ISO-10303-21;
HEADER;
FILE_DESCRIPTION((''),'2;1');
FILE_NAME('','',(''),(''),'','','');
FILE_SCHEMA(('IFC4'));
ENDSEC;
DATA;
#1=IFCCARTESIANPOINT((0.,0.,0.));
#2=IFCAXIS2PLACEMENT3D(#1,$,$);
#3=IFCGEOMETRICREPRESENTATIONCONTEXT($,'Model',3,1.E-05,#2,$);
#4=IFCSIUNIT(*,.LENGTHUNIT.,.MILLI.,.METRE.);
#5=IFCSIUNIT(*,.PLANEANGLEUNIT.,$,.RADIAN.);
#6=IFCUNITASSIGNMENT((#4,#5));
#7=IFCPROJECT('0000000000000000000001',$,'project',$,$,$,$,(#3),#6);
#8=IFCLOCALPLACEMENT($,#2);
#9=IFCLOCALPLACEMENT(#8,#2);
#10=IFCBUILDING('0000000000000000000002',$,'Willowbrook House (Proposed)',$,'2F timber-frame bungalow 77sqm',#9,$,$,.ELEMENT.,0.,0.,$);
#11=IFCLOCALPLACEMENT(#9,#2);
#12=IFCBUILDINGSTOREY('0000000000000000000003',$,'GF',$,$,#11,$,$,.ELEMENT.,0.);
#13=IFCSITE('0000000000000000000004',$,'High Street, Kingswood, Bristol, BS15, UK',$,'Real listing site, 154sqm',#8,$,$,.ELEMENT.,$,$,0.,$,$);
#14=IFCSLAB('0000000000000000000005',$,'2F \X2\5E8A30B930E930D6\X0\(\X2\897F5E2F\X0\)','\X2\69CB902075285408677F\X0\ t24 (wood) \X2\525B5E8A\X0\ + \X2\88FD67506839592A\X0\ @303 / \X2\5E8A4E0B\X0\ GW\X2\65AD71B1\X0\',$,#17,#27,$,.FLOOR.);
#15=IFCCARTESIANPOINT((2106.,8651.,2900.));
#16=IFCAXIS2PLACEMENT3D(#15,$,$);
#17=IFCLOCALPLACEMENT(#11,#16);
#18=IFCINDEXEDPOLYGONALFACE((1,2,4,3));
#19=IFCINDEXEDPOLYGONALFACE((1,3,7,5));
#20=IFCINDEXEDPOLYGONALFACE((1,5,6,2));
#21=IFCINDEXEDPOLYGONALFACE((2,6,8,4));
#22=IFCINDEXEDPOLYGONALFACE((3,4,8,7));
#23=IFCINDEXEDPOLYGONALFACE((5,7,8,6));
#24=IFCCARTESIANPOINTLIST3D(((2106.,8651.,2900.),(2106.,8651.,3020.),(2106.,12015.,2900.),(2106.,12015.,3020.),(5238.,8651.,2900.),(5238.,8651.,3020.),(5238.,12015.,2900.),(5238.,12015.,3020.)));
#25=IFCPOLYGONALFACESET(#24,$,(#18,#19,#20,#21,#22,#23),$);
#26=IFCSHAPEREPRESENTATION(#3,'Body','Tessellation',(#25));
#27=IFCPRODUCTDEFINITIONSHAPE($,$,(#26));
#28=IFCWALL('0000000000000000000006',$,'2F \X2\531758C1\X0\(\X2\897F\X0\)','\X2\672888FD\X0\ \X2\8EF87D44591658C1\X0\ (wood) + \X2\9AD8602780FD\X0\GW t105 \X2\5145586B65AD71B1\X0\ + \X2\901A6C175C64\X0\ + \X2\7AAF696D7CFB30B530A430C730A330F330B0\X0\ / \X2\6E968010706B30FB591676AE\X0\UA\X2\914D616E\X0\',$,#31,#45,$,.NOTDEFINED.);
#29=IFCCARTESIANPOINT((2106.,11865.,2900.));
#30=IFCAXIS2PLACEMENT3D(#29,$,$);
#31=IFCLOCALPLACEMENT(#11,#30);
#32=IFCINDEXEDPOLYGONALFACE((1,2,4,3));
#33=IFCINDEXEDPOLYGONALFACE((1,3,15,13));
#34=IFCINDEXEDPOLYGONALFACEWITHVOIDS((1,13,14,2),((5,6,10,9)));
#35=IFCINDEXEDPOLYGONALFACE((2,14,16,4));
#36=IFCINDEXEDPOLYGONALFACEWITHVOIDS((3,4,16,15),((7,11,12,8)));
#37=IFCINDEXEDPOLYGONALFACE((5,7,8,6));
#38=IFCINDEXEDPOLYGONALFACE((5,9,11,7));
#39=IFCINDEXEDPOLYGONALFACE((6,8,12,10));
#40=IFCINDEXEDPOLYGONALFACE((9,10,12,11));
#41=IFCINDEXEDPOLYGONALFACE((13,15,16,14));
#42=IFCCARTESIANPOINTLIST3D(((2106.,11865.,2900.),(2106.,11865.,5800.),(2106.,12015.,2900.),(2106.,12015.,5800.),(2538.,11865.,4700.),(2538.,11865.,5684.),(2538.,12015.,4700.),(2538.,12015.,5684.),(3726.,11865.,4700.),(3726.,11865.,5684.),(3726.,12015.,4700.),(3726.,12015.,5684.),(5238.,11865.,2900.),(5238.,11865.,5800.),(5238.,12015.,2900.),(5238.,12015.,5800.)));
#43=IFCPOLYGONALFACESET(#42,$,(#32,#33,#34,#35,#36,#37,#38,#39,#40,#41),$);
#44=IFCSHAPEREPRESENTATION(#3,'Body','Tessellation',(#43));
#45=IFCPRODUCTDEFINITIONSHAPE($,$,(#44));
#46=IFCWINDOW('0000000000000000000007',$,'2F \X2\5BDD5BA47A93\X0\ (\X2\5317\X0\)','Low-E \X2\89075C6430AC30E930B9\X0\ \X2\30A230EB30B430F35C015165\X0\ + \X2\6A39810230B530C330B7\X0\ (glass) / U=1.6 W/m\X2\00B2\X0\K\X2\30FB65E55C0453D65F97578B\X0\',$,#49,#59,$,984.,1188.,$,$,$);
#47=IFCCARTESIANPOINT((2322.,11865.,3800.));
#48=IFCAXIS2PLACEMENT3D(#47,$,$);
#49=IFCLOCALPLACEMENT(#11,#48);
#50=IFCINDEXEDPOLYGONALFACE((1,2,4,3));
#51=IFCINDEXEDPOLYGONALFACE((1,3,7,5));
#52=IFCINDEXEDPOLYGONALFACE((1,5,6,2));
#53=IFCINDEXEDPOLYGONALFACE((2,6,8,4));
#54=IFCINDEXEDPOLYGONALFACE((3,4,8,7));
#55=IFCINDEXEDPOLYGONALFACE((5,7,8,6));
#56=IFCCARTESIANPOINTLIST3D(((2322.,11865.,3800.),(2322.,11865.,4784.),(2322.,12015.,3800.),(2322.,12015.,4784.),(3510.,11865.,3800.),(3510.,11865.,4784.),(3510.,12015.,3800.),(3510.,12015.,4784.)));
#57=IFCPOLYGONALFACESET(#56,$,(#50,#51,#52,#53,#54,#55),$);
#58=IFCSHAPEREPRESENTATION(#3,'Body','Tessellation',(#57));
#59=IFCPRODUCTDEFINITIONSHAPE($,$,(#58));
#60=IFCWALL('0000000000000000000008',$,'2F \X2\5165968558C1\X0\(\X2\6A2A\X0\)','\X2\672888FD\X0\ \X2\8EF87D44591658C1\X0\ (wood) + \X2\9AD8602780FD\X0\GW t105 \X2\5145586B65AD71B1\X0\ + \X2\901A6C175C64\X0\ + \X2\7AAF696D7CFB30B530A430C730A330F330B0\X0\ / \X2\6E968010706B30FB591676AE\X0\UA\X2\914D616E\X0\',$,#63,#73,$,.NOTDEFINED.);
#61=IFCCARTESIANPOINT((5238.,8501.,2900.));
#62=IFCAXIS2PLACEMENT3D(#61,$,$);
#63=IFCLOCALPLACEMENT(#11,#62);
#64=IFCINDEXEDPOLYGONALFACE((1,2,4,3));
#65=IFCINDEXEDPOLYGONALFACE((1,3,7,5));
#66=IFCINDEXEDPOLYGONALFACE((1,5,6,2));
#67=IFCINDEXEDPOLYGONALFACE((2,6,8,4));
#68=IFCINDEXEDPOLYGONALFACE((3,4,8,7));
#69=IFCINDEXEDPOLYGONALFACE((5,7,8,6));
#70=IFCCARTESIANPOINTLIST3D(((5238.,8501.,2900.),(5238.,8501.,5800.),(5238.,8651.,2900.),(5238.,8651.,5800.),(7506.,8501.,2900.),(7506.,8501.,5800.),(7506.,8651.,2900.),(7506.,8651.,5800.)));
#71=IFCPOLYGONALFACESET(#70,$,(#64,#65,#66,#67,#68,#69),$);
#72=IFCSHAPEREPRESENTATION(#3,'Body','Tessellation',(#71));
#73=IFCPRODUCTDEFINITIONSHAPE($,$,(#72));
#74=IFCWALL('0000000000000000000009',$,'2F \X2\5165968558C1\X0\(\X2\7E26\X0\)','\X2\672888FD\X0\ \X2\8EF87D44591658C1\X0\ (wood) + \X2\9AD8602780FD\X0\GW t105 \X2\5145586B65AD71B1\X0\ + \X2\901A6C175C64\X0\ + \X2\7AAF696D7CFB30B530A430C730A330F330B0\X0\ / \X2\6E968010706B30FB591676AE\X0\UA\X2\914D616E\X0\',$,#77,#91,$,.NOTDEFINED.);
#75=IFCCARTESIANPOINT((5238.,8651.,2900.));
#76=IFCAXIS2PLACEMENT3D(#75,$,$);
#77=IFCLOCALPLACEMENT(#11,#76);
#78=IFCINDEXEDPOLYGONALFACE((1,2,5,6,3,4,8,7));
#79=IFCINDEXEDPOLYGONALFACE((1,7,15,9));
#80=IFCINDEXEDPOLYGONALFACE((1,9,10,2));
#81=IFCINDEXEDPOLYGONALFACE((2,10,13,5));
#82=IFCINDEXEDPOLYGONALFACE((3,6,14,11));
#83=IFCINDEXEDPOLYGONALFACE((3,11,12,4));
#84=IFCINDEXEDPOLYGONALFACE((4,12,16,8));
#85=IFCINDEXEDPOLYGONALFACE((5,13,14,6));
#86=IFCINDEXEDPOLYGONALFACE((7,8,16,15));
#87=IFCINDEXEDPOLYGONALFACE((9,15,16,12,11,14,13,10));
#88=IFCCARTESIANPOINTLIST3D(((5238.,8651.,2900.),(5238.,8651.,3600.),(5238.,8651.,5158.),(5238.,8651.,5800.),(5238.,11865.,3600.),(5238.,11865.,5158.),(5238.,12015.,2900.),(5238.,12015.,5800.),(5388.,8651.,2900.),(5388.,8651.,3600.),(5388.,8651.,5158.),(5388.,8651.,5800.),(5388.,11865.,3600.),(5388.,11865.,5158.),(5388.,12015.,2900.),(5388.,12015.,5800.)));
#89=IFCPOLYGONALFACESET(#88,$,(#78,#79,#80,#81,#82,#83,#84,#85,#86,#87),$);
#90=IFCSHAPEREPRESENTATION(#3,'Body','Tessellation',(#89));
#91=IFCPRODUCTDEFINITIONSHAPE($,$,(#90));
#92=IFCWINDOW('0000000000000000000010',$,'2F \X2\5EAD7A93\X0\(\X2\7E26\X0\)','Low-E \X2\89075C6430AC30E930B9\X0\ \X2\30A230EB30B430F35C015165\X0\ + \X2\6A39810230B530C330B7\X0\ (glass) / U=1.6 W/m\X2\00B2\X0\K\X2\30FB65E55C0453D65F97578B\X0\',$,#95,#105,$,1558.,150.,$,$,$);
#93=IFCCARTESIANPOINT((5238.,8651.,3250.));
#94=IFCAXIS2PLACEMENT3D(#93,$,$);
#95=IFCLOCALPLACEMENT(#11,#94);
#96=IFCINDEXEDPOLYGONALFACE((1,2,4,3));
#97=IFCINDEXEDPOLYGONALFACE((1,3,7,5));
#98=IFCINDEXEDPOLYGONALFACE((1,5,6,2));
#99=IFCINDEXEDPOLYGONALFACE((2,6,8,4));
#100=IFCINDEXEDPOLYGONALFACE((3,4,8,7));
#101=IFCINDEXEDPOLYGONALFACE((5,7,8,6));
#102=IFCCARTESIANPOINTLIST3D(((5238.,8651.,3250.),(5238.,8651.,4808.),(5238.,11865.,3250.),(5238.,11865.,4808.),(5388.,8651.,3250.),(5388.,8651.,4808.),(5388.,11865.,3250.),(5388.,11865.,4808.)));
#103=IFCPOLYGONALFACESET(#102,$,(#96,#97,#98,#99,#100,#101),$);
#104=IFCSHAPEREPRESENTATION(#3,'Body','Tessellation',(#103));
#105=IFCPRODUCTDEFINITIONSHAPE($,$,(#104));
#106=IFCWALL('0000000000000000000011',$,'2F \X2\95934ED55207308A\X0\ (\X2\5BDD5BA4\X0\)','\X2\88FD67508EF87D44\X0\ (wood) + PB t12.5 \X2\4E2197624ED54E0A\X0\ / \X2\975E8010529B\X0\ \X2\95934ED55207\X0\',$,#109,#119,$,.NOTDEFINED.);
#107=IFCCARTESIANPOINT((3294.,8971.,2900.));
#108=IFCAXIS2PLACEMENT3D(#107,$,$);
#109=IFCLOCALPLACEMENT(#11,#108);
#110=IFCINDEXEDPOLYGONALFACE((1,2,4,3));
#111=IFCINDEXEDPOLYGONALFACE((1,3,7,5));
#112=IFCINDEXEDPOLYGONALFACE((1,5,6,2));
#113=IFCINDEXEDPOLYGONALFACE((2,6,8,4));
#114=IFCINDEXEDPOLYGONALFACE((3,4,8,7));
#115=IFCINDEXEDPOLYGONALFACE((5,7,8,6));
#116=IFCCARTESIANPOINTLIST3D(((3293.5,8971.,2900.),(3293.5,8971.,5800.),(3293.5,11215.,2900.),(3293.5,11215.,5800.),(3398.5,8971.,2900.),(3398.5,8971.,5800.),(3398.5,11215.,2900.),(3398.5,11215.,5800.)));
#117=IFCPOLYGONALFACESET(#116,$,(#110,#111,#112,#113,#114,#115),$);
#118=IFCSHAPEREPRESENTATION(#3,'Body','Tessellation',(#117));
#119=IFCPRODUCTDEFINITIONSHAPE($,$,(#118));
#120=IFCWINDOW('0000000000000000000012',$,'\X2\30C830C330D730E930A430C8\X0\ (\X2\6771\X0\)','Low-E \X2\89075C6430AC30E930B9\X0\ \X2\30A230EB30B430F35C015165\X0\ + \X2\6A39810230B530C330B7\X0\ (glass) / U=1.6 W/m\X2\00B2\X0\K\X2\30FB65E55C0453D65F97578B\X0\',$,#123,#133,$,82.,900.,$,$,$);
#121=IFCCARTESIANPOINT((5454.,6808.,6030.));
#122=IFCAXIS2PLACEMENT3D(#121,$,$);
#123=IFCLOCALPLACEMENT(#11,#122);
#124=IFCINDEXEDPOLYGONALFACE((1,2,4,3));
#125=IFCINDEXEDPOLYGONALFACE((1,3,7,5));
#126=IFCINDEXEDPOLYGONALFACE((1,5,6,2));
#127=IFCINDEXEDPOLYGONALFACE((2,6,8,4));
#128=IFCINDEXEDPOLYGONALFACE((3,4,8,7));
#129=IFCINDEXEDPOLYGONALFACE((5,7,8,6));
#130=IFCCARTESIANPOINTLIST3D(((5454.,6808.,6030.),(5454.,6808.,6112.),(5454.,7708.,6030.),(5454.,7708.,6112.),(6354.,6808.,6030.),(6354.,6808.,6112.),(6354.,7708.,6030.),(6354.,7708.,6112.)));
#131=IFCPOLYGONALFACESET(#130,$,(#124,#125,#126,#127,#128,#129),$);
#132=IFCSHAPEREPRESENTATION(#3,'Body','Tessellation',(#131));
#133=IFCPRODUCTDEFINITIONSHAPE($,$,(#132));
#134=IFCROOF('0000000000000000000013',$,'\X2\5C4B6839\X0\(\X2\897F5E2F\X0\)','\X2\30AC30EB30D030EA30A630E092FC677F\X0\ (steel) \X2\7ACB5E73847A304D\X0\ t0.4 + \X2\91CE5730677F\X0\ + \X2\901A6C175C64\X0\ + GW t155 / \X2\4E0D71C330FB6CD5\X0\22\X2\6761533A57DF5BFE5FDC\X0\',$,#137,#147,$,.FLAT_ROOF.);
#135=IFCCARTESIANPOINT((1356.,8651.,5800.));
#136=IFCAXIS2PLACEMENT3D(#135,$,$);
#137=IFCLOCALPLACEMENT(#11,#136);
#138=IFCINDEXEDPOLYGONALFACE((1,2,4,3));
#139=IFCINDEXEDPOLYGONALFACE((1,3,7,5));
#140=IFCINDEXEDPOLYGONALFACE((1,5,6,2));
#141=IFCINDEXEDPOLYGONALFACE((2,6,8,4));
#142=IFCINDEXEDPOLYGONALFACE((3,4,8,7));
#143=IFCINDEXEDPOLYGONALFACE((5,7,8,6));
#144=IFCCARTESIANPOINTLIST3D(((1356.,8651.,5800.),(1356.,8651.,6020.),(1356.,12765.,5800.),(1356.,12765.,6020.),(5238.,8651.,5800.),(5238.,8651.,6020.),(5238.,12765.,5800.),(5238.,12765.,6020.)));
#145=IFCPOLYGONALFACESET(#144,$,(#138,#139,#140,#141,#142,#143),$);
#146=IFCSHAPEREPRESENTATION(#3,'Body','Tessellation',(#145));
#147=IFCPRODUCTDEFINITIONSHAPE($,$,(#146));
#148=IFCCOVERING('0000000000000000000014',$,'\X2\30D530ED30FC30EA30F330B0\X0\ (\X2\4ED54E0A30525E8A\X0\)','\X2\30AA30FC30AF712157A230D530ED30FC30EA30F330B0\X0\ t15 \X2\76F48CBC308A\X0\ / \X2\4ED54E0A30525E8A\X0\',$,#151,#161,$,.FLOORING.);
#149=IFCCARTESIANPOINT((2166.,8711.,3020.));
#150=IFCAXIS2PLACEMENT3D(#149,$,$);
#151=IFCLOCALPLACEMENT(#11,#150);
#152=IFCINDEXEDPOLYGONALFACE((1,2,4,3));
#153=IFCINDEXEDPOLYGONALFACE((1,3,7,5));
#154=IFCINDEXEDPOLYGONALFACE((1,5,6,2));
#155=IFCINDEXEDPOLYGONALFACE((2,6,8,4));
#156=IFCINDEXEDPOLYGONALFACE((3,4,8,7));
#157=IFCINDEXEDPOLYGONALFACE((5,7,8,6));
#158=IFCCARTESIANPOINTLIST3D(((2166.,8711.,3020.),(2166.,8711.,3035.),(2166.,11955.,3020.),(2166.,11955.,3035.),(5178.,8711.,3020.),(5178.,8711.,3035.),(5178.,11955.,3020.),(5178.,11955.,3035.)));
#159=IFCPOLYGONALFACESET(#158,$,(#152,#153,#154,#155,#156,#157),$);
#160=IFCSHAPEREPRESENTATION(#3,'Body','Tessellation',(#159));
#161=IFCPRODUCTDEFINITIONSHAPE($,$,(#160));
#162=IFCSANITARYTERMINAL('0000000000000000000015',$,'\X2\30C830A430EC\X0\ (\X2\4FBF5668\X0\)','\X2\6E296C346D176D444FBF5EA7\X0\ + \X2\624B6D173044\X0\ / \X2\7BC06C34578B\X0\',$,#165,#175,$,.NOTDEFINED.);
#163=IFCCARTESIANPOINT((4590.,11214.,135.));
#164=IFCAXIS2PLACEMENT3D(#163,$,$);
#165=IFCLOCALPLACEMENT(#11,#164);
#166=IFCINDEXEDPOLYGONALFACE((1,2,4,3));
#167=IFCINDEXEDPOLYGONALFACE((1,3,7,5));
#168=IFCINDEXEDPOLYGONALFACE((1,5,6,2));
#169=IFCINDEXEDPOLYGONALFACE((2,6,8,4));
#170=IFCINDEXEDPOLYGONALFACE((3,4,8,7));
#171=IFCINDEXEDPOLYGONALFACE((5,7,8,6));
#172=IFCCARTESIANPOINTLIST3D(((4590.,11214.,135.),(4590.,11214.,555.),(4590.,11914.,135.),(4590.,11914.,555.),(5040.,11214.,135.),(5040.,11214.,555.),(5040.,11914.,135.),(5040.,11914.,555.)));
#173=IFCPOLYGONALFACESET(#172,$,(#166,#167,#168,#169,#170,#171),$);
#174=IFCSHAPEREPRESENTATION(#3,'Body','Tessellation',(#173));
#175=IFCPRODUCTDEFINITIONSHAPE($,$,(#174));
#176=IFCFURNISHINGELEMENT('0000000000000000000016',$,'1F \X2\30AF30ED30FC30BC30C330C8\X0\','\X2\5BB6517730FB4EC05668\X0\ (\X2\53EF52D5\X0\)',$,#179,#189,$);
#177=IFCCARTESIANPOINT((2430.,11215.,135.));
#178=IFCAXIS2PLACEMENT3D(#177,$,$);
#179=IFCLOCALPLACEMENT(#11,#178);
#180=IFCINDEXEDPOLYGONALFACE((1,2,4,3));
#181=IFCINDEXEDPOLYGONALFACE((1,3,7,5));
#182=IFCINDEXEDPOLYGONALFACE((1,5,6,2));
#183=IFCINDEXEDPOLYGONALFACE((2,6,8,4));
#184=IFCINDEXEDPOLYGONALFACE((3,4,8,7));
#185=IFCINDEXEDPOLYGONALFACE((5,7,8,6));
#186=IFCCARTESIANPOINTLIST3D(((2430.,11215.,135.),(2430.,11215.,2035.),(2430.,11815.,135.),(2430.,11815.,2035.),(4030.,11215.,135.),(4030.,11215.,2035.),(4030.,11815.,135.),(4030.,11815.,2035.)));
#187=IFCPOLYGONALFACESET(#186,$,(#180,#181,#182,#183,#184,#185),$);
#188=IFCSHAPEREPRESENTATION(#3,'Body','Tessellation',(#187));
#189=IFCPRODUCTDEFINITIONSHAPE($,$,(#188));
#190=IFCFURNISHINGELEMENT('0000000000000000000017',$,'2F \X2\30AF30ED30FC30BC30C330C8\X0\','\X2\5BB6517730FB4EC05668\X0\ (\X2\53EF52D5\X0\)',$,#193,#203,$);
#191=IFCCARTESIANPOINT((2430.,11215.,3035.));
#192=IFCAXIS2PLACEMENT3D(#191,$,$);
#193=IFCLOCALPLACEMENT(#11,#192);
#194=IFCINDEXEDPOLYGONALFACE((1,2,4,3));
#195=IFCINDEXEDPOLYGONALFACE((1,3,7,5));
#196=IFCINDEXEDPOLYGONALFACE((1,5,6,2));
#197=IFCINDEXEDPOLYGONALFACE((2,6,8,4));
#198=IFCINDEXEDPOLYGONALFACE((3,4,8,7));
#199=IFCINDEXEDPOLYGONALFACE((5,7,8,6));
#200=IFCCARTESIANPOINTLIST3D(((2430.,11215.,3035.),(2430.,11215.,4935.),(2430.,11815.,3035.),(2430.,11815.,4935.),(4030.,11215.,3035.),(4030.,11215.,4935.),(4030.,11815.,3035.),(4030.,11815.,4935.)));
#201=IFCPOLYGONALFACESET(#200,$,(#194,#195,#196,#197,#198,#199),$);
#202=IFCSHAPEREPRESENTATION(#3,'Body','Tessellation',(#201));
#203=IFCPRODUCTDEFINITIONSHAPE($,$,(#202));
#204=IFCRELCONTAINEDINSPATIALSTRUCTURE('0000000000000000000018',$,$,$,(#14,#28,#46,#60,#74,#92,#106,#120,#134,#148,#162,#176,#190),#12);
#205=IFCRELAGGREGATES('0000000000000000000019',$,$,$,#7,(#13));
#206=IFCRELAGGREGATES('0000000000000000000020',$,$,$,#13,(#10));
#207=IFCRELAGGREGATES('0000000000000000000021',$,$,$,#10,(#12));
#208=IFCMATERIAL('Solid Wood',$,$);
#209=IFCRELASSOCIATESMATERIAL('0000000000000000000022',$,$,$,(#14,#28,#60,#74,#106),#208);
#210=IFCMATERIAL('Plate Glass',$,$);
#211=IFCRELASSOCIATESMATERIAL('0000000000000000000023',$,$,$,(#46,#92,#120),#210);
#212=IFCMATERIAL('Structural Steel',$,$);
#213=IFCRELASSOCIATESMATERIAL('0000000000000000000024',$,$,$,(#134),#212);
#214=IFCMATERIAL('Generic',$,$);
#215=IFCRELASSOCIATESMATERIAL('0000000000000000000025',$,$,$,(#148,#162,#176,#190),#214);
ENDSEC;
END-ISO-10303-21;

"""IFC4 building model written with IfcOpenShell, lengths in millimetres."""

from ifc_helpers import new_model, si_unit, frame, frame_2d, origin, place, context, project, spatial, rectangle, extrude, material, element, fill, save


model = new_model("IFC4")

# Units and contexts
model_context = context("Model", 3, precision=1e-05, world=origin())
ifc_project = project(units=[si_unit("LENGTHUNIT", "METRE", prefix="MILLI"), si_unit("PLANEANGLEUNIT", "RADIAN")], contexts=[model_context])

# Site, building, storey
site_placement = place(None, origin())
site = spatial("IfcSite", under=ifc_project, at=site_placement, Name="High Street, Kingswood, Bristol, BS15, UK", ObjectType="Real listing site, 154sqm", CompositionType="ELEMENT", RefElevation=0.0)
building_placement = place(site_placement, origin())
building = spatial("IfcBuilding", under=site, at=building_placement, Name="Willowbrook House (Proposed)", ObjectType="2F timber-frame bungalow 77sqm", CompositionType="ELEMENT", ElevationOfRefHeight=0.0, ElevationOfTerrain=0.0)
storey_placement = place(building_placement, origin())
storey = spatial("IfcBuildingStorey", under=building, at=storey_placement, Name="GF", CompositionType="ELEMENT", Elevation=0.0)

# Slab
ifc_material_1 = material(Name="Solid Wood")
slab_placement = place(storey_placement, frame((2106.0, 8651.0, 2900.0)))
element("IfcSlab", 1, at=slab_placement, inside=storey, material=ifc_material_1, Name="2F 床スラブ(西帯)", Description="構造用合板 t24 (wood) 剛床 + 製材根太 @303 / 床下 GW断熱", PredefinedType="FLOOR", context=model_context, shape_type="SweptSolid", body=[
    extrude(rectangle(XDim=3132.0, YDim=3364.0, at=frame_2d((1566.0, 1682.0))), frame((2106.0, 8651.0, 2900.0)), (0.0, 0.0, 1.0), 120.0),
])

# Wall, opening, window
wall_1_placement = place(storey_placement, frame((2106.0, 11865.0, 2900.0)))
wall_1 = element("IfcWall", 2, at=wall_1_placement, inside=storey, material=ifc_material_1, Name="2F 北壁(西)", Description="木製 軸組外壁 (wood) + 高性能GW t105 充填断熱 + 通気層 + 窯業系サイディング / 準耐火・外皮UA配慮", PredefinedType="NOTDEFINED", context=model_context, shape_type="SweptSolid", body=[
    extrude(rectangle(XDim=3132.0, YDim=150.0, at=frame_2d((1566.0, 75.0))), frame((2106.0, 11865.0, 2900.0)), (0.0, 0.0, 1.0), 2900.0),
])
opening_1_placement = place(storey_placement, frame((2322.0, 11865.0, 3800.0)))
opening_1 = element("IfcOpeningElement", 3, at=opening_1_placement, cuts=wall_1, PredefinedType="NOTDEFINED", context=model_context, shape_type="SweptSolid", body=[
    extrude(rectangle(XDim=1188.0, YDim=150.0, at=frame_2d((594.0, 75.0))), frame((2322.0, 11865.0, 3800.0)), (0.0, 0.0, 1.0), 984.0),
])
ifc_material_2 = material(Name="Plate Glass")
window_1_placement = place(storey_placement, frame((2322.0, 11865.0, 3800.0)))
window_1 = element("IfcWindow", 4, at=window_1_placement, inside=storey, material=ifc_material_2, Name="2F 寝室窓 (北)", Description="Low-E 複層ガラス アルゴン封入 + 樹脂サッシ (glass) / U=1.6 W/m²K・日射取得型", OverallHeight=984.0, OverallWidth=1188.0, context=model_context, shape_type="SweptSolid", body=[
    extrude(rectangle(XDim=1188.0, YDim=150.0, at=frame_2d((594.0, 75.0))), frame((2322.0, 11865.0, 3800.0)), (0.0, 0.0, 1.0), 984.0),
])
fill(opening_1, window_1)

# Wall
wall_2_placement = place(storey_placement, frame((5238.0, 8501.0, 2900.0)))
element("IfcWall", 5, at=wall_2_placement, inside=storey, material=ifc_material_1, Name="2F 入隅壁(横)", Description="木製 軸組外壁 (wood) + 高性能GW t105 充填断熱 + 通気層 + 窯業系サイディング / 準耐火・外皮UA配慮", PredefinedType="NOTDEFINED", context=model_context, shape_type="SweptSolid", body=[
    extrude(rectangle(XDim=2268.0, YDim=150.0, at=frame_2d((1134.0, 75.0))), frame((5238.0, 8501.0, 2900.0)), (0.0, 0.0, 1.0), 2900.0),
])

# Wall, opening, window
wall_3_placement = place(storey_placement, frame((5238.0, 8651.0, 2900.0)))
wall_3 = element("IfcWall", 6, at=wall_3_placement, inside=storey, material=ifc_material_1, Name="2F 入隅壁(縦)", Description="木製 軸組外壁 (wood) + 高性能GW t105 充填断熱 + 通気層 + 窯業系サイディング / 準耐火・外皮UA配慮", PredefinedType="NOTDEFINED", context=model_context, shape_type="SweptSolid", body=[
    extrude(rectangle(XDim=150.0, YDim=3364.0, at=frame_2d((75.0, 1682.0))), frame((5238.0, 8651.0, 2900.0)), (0.0, 0.0, 1.0), 2900.0),
])
opening_2_placement = place(storey_placement, frame((5238.0, 8651.0, 3250.0)))
opening_2 = element("IfcOpeningElement", 7, at=opening_2_placement, cuts=wall_3, PredefinedType="NOTDEFINED", context=model_context, shape_type="SweptSolid", body=[
    extrude(rectangle(XDim=150.0, YDim=3214.0, at=frame_2d((75.0, 1607.0))), frame((5238.0, 8651.0, 3250.0)), (0.0, 0.0, 1.0), 1558.0),
])
window_2_placement = place(storey_placement, frame((5238.0, 8651.0, 3250.0)))
window_2 = element("IfcWindow", 8, at=window_2_placement, inside=storey, material=ifc_material_2, Name="2F 庭窓(縦)", Description="Low-E 複層ガラス アルゴン封入 + 樹脂サッシ (glass) / U=1.6 W/m²K・日射取得型", OverallHeight=1558.0, OverallWidth=150.0, context=model_context, shape_type="SweptSolid", body=[
    extrude(rectangle(XDim=150.0, YDim=3214.0, at=frame_2d((75.0, 1607.0))), frame((5238.0, 8651.0, 3250.0)), (0.0, 0.0, 1.0), 1558.0),
])
fill(opening_2, window_2)

# Wall
wall_4_placement = place(storey_placement, frame((3294.0, 8971.0, 2900.0)))
element("IfcWall", 9, at=wall_4_placement, inside=storey, material=ifc_material_1, Name="2F 間仕切り (寝室)", Description="製材軸組 (wood) + PB t12.5 両面仕上 / 非耐力 間仕切", PredefinedType="NOTDEFINED", context=model_context, shape_type="SweptSolid", body=[
    extrude(rectangle(XDim=105.0, YDim=2244.0, at=frame_2d((52.0, 1122.0))), frame((3294.0, 8971.0, 2900.0)), (0.0, 0.0, 1.0), 2900.0),
])

# Window
window_3_placement = place(storey_placement, frame((5454.0, 6808.0, 6030.0)))
element("IfcWindow", 10, at=window_3_placement, inside=storey, material=ifc_material_2, Name="トップライト (東)", Description="Low-E 複層ガラス アルゴン封入 + 樹脂サッシ (glass) / U=1.6 W/m²K・日射取得型", OverallHeight=82.0, OverallWidth=900.0, context=model_context, shape_type="SweptSolid", body=[
    extrude(rectangle(XDim=900.0, YDim=900.0, at=frame_2d((450.0, 450.0))), frame((5454.0, 6808.0, 6030.0)), (0.0, 0.0, 1.0), 82.0),
])

# Roof
ifc_material_3 = material(Name="Structural Steel")
for number, where, name in (
    (11, (1356.0, 8651.0, 5800.0), "屋根(西帯)"),
):
    element("IfcRoof", number, at=place(storey_placement, frame(where)), inside=storey, material=ifc_material_3, Name=name, Description="ガルバリウム鋼板 (steel) 立平葺き t0.4 + 野地板 + 通気層 + GW t155 / 不燃・法22条区域対応", PredefinedType="FLAT_ROOF", context=model_context, shape_type="SweptSolid", body=[
        extrude(rectangle(XDim=3882.0, YDim=4114.0, at=frame_2d((1941.0, 2057.0))), frame((1356.0, 8651.0, 5800.0)), (0.0, 0.0, 1.0), 220.0),
    ])

# Covering
ifc_material_4 = material(Name="Generic")
covering_placement = place(storey_placement, frame((2166.0, 8711.0, 3020.0)))
element("IfcCovering", 12, at=covering_placement, inside=storey, material=ifc_material_4, Name="フローリング (仕上げ床)", Description="オーク無垢フローリング t15 直貼り / 仕上げ床", PredefinedType="FLOORING", context=model_context, shape_type="SweptSolid", body=[
    extrude(rectangle(XDim=3012.0, YDim=3244.0, at=frame_2d((1506.0, 1622.0))), frame((2166.0, 8711.0, 3020.0)), (0.0, 0.0, 1.0), 15.0),
])

# Sanitary terminal
sanitary_terminal_placement = place(storey_placement, frame((4590.0, 11214.0, 135.0)))
element("IfcSanitaryTerminal", 13, at=sanitary_terminal_placement, inside=storey, material=ifc_material_4, Name="トイレ (便器)", Description="温水洗浄便座 + 手洗い / 節水型", PredefinedType="NOTDEFINED", context=model_context, shape_type="SweptSolid", body=[
    extrude(rectangle(XDim=450.0, YDim=700.0, at=frame_2d((225.0, 350.0))), frame((4590.0, 11214.0, 135.0)), (0.0, 0.0, 1.0), 420.0),
])

# Furnishing elements
furnishing_1_placement = place(storey_placement, frame((2430.0, 11215.0, 135.0)))
element("IfcFurnishingElement", 14, at=furnishing_1_placement, inside=storey, material=ifc_material_4, Name="1F クローゼット", Description="家具・什器 (可動)", context=model_context, shape_type="SweptSolid", body=[
    extrude(rectangle(XDim=1600.0, YDim=600.0, at=frame_2d((800.0, 300.0))), frame((2430.0, 11215.0, 135.0)), (0.0, 0.0, 1.0), 1900.0),
])
furnishing_2_placement = place(storey_placement, frame((2430.0, 11215.0, 3035.0)))
element("IfcFurnishingElement", 15, at=furnishing_2_placement, inside=storey, material=ifc_material_4, Name="2F クローゼット", Description="家具・什器 (可動)", context=model_context, shape_type="SweptSolid", body=[
    extrude(rectangle(XDim=1600.0, YDim=600.0, at=frame_2d((800.0, 300.0))), frame((2430.0, 11215.0, 3035.0)), (0.0, 0.0, 1.0), 1900.0),
])

save(model, "model.ifc")
